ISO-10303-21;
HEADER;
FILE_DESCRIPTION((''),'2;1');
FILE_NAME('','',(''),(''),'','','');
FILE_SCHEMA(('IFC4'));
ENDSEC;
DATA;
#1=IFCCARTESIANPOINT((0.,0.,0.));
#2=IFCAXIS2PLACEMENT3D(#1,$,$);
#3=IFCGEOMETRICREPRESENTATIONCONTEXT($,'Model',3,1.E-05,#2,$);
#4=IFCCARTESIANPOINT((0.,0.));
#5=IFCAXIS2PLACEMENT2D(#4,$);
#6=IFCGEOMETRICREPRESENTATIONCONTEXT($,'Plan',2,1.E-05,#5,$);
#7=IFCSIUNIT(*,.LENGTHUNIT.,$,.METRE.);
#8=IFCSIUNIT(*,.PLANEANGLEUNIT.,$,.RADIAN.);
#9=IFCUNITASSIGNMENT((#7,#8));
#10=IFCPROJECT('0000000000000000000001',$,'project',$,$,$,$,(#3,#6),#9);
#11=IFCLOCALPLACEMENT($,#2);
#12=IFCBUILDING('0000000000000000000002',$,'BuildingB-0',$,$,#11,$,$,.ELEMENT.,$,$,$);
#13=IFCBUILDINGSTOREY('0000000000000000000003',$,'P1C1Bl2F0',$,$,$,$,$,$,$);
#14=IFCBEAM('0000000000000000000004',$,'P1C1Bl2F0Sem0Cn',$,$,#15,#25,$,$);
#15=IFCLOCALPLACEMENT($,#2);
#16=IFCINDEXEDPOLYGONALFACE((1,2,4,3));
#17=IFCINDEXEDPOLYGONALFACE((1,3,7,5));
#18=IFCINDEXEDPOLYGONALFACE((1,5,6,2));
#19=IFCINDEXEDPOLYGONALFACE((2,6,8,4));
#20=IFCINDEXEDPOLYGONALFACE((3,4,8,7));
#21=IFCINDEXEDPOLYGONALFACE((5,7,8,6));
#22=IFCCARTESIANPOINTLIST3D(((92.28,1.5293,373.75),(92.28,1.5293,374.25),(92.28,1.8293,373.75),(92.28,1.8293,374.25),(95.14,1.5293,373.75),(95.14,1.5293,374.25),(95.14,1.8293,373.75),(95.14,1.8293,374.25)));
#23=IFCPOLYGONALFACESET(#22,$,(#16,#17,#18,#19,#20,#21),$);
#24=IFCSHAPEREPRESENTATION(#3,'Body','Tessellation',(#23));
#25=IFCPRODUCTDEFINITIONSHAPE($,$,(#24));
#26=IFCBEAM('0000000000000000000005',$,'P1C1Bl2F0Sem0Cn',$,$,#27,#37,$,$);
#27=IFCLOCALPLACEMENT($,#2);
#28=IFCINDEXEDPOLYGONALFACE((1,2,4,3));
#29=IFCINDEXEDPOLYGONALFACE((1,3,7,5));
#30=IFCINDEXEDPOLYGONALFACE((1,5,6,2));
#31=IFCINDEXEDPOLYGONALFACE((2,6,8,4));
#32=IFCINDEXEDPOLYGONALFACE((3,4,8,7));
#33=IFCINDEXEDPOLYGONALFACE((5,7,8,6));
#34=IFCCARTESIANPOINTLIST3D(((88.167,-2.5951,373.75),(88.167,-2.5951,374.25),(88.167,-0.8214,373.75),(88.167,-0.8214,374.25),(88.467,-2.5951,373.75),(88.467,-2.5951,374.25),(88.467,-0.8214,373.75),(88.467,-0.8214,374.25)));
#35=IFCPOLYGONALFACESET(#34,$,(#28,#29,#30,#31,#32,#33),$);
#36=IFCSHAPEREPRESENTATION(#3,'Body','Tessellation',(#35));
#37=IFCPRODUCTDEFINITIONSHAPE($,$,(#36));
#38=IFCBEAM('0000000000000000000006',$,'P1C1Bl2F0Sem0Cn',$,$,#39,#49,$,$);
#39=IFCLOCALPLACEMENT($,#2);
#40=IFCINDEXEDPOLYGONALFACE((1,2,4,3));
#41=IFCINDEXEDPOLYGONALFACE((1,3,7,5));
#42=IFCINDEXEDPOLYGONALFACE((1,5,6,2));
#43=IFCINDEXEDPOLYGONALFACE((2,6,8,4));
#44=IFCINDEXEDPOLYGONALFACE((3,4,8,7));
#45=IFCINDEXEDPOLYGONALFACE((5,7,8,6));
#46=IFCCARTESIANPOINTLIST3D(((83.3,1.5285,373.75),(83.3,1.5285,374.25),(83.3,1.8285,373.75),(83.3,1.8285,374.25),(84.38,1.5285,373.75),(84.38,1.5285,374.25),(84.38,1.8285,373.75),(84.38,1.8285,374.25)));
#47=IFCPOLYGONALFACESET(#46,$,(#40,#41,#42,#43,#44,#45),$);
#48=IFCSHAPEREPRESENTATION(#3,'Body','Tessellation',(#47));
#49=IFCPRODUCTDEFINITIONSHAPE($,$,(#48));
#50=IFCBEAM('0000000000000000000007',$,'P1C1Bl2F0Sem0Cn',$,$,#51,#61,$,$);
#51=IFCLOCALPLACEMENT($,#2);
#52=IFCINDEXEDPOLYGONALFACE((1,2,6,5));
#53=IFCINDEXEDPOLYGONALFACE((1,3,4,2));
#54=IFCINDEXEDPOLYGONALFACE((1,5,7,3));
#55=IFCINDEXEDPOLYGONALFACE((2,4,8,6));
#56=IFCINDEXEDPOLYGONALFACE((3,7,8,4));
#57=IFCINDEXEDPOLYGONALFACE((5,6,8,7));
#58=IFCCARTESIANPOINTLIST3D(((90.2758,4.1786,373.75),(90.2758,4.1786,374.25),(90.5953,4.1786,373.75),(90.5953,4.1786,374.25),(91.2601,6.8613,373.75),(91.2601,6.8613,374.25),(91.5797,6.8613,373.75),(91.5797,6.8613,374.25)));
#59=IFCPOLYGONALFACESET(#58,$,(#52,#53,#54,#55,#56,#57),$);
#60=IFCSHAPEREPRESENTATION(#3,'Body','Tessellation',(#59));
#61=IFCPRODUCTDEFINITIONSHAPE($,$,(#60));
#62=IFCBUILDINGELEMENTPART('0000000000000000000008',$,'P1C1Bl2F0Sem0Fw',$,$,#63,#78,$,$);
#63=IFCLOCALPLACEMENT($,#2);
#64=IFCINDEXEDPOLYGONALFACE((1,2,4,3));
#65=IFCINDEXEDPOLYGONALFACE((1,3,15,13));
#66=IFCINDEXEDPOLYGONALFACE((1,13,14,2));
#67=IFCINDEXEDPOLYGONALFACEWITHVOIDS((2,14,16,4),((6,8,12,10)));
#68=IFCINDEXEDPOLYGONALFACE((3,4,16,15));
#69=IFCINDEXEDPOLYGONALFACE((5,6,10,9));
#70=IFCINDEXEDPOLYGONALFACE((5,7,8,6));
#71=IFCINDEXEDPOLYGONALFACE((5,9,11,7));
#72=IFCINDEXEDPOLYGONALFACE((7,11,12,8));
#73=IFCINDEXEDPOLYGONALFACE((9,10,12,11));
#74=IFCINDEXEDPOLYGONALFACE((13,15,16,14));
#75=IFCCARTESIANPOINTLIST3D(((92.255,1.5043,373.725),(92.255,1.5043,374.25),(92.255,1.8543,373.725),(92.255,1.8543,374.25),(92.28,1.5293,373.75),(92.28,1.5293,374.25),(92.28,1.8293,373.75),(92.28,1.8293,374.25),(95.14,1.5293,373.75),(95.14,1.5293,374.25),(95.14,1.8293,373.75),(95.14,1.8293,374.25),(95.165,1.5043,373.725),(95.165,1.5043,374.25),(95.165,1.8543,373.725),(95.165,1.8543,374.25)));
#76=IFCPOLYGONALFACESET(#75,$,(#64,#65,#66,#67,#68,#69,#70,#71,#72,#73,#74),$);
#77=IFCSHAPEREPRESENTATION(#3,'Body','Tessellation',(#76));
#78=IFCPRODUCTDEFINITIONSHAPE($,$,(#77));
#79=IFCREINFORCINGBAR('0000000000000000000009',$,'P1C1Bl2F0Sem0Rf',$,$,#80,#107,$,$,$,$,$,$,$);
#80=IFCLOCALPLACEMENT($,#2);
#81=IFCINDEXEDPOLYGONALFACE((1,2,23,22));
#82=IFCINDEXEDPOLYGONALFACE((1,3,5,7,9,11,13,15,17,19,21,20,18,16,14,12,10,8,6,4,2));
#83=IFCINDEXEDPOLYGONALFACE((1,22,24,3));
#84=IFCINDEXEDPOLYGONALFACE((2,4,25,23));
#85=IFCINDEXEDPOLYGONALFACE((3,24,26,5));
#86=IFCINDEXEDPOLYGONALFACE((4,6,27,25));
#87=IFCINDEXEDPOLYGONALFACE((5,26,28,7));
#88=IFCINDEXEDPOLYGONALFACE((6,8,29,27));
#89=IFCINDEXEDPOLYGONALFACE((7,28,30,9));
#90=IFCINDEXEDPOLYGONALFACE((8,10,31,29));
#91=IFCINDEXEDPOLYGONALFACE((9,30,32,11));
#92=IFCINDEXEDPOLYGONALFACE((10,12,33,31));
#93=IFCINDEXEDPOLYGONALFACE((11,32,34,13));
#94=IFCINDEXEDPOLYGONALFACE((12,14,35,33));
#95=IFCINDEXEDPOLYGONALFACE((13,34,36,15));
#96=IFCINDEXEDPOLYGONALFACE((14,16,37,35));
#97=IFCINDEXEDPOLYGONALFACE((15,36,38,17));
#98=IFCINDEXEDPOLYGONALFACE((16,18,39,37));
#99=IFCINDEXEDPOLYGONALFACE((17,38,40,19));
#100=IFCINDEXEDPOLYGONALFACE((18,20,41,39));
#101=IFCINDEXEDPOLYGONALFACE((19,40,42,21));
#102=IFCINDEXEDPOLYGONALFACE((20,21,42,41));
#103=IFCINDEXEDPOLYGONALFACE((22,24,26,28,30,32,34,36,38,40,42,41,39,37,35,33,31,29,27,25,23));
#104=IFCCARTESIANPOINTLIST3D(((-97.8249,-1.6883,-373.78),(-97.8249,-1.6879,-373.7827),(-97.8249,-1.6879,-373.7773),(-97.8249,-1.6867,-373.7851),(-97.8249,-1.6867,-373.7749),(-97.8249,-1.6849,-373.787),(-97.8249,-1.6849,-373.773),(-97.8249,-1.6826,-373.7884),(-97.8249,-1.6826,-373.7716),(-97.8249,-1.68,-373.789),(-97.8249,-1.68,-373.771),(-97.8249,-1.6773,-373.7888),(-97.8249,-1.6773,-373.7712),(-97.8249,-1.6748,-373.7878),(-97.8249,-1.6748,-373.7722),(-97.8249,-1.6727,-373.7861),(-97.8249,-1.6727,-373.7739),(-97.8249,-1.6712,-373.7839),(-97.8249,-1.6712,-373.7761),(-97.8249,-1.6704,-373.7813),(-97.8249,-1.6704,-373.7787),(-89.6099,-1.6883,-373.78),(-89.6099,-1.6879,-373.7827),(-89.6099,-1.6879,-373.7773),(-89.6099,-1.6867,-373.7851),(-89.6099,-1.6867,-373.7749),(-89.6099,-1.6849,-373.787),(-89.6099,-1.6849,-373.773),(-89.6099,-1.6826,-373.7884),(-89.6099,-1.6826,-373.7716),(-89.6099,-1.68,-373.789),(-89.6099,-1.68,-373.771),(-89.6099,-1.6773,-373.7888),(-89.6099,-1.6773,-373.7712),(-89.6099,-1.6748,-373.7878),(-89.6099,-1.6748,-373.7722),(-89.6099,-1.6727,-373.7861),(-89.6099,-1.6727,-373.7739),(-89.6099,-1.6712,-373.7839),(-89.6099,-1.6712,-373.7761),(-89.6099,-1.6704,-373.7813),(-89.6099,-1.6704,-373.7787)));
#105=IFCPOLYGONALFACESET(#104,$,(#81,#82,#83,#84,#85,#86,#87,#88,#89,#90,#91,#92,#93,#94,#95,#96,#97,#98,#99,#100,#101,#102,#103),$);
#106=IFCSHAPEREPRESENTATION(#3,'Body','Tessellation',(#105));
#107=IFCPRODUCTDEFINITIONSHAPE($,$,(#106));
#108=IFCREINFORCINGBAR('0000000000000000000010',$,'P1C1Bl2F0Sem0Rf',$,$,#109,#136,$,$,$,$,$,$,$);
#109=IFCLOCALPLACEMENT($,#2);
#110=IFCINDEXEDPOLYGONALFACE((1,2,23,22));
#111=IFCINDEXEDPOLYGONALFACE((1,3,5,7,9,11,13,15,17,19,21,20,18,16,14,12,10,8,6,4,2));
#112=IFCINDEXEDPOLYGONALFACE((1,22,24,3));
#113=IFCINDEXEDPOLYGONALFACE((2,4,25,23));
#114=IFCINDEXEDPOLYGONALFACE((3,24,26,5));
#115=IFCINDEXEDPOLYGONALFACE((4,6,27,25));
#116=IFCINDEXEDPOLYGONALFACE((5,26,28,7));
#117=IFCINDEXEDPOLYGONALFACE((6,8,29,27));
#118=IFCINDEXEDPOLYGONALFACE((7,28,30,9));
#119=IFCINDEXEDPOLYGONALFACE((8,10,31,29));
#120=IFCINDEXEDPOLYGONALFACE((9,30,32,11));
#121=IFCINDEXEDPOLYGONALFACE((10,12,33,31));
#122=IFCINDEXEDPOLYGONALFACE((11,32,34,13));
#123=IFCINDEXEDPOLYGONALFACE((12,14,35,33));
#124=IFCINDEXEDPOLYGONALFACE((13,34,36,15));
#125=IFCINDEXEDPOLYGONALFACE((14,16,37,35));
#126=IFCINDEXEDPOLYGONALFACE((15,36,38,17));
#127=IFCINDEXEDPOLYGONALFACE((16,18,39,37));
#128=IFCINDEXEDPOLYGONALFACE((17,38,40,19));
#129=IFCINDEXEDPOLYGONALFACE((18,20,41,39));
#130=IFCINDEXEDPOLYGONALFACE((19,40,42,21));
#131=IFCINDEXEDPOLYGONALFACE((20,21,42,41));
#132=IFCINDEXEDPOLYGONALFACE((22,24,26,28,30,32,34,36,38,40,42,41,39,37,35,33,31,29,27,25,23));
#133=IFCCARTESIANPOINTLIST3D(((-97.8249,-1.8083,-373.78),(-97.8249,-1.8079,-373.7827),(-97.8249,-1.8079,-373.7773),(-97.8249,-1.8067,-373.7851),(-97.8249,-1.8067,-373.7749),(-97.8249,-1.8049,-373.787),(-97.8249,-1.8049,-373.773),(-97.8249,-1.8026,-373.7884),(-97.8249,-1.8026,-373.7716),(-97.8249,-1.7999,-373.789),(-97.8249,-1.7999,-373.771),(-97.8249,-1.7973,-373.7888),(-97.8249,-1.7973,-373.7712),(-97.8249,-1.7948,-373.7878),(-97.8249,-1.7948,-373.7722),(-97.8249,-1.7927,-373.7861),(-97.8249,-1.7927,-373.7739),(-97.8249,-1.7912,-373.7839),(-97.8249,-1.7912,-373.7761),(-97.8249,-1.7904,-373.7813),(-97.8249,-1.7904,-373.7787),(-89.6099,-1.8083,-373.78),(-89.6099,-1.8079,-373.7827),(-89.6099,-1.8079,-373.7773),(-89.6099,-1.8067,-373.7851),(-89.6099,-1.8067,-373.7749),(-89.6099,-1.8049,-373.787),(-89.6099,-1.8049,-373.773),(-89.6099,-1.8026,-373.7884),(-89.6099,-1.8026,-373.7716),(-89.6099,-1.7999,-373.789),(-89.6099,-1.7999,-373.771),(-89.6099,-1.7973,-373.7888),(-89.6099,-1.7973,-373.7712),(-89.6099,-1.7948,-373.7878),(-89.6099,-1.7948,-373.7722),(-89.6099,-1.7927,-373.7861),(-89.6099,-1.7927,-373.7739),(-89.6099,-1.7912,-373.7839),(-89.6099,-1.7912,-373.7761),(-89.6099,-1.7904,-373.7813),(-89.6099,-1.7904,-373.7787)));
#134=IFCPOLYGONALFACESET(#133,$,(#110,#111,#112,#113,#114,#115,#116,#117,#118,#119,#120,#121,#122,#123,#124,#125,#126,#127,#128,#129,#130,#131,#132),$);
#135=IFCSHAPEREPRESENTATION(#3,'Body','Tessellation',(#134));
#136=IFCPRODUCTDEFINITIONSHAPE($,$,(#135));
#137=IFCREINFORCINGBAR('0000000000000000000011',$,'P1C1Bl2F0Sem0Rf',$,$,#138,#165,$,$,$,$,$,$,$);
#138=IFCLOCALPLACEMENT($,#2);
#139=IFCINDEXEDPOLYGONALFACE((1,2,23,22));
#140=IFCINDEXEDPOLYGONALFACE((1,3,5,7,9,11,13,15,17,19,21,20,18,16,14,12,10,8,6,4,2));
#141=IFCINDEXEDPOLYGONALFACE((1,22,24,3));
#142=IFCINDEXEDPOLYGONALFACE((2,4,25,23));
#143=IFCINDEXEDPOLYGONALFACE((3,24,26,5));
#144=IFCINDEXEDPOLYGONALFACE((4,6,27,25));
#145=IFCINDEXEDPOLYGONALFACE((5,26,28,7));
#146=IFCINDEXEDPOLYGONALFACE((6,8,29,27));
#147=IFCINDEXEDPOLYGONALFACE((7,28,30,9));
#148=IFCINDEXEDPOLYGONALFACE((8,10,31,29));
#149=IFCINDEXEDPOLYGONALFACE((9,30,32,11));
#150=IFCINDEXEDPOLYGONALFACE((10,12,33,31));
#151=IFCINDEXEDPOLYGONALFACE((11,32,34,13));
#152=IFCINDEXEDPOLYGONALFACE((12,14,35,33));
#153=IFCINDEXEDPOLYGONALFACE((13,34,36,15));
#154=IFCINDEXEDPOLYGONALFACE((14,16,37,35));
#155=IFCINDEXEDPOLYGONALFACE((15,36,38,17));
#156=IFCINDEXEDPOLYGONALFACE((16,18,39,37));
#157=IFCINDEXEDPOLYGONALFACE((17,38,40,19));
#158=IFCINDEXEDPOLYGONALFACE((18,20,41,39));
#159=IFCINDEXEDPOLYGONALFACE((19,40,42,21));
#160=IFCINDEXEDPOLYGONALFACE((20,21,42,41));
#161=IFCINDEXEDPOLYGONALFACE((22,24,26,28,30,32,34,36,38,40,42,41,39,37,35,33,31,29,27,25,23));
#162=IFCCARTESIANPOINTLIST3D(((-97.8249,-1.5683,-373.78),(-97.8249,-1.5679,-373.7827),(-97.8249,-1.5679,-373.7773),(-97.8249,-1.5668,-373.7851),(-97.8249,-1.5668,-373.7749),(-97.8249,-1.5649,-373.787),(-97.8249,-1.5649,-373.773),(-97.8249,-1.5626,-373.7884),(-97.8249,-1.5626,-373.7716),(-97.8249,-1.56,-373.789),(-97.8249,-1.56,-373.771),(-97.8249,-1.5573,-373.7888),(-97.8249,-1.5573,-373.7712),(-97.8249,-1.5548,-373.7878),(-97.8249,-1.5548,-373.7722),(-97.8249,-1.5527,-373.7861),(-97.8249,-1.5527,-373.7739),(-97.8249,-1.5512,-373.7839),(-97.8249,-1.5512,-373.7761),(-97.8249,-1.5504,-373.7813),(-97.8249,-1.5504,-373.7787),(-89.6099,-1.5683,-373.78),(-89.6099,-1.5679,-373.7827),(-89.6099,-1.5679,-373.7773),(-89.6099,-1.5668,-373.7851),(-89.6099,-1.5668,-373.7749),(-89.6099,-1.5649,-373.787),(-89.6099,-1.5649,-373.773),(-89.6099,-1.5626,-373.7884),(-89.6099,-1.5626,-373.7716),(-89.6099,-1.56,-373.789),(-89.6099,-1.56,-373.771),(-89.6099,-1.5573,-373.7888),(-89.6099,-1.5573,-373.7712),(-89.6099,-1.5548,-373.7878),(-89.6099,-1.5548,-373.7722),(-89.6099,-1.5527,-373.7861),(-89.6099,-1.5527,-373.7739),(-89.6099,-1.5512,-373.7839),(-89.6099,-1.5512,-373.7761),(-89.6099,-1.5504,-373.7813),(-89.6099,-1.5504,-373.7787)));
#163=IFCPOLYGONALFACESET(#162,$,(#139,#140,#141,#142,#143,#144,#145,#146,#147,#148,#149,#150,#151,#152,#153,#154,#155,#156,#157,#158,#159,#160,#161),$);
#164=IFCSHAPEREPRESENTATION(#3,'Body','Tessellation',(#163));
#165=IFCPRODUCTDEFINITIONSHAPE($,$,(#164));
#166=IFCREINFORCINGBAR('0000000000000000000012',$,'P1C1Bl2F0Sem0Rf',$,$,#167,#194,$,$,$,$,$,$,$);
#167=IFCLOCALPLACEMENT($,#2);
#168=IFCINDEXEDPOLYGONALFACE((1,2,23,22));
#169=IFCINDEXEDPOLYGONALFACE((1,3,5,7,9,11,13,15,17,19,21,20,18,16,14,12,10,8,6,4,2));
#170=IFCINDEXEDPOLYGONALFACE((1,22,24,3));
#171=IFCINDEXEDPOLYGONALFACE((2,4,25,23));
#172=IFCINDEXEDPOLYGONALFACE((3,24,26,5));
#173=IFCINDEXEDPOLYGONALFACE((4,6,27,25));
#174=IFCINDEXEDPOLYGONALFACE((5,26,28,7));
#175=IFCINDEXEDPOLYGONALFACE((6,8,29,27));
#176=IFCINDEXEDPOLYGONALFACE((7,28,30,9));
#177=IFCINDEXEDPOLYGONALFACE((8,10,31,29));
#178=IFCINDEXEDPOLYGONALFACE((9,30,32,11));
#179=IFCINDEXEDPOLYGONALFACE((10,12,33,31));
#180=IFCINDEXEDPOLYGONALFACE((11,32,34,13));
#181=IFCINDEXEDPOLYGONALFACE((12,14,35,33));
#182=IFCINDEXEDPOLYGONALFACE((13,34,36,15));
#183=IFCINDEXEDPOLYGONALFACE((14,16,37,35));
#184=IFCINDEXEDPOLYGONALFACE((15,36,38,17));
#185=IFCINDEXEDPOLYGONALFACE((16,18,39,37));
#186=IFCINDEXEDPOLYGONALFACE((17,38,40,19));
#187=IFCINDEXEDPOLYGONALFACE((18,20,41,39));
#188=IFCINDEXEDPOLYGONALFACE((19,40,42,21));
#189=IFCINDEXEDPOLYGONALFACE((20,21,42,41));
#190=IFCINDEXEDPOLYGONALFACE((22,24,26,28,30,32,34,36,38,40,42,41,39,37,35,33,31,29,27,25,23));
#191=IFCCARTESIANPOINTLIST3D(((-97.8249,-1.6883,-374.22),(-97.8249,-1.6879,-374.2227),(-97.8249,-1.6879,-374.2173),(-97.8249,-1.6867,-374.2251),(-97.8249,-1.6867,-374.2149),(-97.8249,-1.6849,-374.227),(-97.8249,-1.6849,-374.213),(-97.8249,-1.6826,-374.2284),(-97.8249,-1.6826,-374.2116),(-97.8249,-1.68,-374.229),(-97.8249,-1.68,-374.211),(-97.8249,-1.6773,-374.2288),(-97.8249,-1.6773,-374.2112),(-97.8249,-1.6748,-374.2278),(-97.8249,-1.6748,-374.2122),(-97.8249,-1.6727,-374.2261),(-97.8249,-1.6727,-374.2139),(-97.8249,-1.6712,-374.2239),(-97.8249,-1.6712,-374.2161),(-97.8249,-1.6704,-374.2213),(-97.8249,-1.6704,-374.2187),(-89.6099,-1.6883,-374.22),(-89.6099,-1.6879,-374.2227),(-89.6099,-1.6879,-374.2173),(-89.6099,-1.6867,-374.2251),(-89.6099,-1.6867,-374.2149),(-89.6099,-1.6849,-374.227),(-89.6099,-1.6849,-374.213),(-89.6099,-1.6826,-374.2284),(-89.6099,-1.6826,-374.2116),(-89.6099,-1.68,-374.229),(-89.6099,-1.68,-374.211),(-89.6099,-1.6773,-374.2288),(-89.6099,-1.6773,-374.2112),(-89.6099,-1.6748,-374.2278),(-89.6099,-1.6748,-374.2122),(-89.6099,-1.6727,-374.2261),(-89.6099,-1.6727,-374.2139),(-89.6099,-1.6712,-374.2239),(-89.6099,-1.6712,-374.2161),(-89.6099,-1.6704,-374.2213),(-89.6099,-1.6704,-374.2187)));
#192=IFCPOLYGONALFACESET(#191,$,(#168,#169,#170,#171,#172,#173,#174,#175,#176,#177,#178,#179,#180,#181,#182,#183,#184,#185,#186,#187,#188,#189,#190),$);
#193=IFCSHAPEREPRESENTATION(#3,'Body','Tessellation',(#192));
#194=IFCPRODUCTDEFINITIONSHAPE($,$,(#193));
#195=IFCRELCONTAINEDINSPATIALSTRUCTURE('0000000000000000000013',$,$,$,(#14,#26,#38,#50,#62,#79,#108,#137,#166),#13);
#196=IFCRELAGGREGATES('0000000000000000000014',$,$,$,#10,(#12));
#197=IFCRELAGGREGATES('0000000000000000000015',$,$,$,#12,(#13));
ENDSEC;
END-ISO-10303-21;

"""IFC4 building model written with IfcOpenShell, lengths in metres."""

from ifc_helpers import new_model, entity, si_unit, origin, origin_2d, place, context, project, spatial, polyline, outline, extrude, element, save


model = new_model("IFC4")

# Units and contexts
model_context = context("Model", 3, precision=1e-05, world=origin())
plan_context = context("Plan", 2, precision=1e-05, world=origin_2d())
ifc_project = project(units=[si_unit("LENGTHUNIT", "METRE"), si_unit("PLANEANGLEUNIT", "RADIAN")], contexts=[model_context, plan_context])

# Building, storey
building_placement = place(None, origin())
building = spatial("IfcBuilding", under=ifc_project, at=building_placement, Name="BuildingB-0", CompositionType="ELEMENT")
storey = spatial("IfcBuildingStorey", under=building, Name="P1C1Bl2F0")

# Beams
element("IfcBeam", 1, inside=storey, Name="P1C1Bl2F0Sem0Cn", context=model_context, shape_type="SweptSolid", body=[
    extrude(outline(polyline([(95.14, 1.5293, 373.75), (95.14, 1.8293, 373.75), (92.28, 1.8293, 373.75), (92.28, 1.5293, 373.75), (95.14, 1.5293, 373.75)])), None, (0.0, 0.0, 1.0), 0.5),
])
element("IfcBeam", 2, inside=storey, Name="P1C1Bl2F0Sem0Cn", context=model_context, shape_type="SweptSolid", body=[
    extrude(outline(polyline([(88.467, -2.5951, 373.75), (88.467, -0.8214, 373.75), (88.167, -0.8214, 373.75), (88.167, -2.5951, 373.75), (88.467, -2.5951, 373.75)])), None, (0.0, 0.0, 1.0), 0.5),
])
element("IfcBeam", 3, inside=storey, Name="P1C1Bl2F0Sem0Cn", context=model_context, shape_type="SweptSolid", body=[
    extrude(outline(polyline([(84.38, 1.5285, 373.75), (84.38, 1.8285, 373.75), (83.3, 1.8285, 373.75), (83.3, 1.5285, 373.75), (84.38, 1.5285, 373.75)])), None, (0.0, 0.0, 1.0), 0.5),
])
element("IfcBeam", 4, inside=storey, Name="P1C1Bl2F0Sem0Cn", context=model_context, shape_type="SweptSolid", body=[
    extrude(outline(polyline([(90.5953, 4.1786, 373.75), (90.2758, 4.1786, 373.75), (91.2601, 6.8613, 373.75), (91.5797, 6.8613, 373.75), (90.5953, 4.1786, 373.75)])), None, (0.0, 0.0, 1.0), 0.5),
])

# Building element part, opening
building_element_part_1 = element("IfcBuildingElementPart", 5, inside=storey, Name="P1C1Bl2F0Sem0Fw", context=model_context, shape_type="SweptSolid", body=[
    extrude(outline(polyline([(95.165, 1.5043, 373.725), (95.165, 1.8543, 373.725), (92.255, 1.8543, 373.725), (92.255, 1.5043, 373.725), (95.165, 1.5043, 373.725)])), None, (0.0, 0.0, 1.0), 0.525),
])
element("IfcOpeningElement", 6, inside=storey, cuts=building_element_part_1, context=model_context, shape_type="SweptSolid", body=[
    extrude(outline(polyline([(95.14, 1.5293, 373.75), (95.14, 1.8293, 373.75), (92.28, 1.8293, 373.75), (92.28, 1.5293, 373.75), (95.14, 1.5293, 373.75)])), None, (0.0, 0.0, 1.0), 0.5),
])

# Reinforcing bars
element("IfcReinforcingBar", 7, inside=storey, Name="P1C1Bl2F0Sem0Rf", context=model_context, shape_type="SweptSolid", body=[
    entity("IfcSurfaceCurveSweptAreaSolid", entity("IfcCircleProfileDef", "AREA", None, None, 0.009), None, entity("IfcPolyline", [entity("IfcCartesianPoint", [97.8249, 1.6793, 373.78]), entity("IfcCartesianPoint", [89.6099, 1.6793, 373.78])]), None, None, entity("IfcPlane", entity("IfcAxis2Placement3D", entity("IfcCartesianPoint", [97.8249, 1.6793, 373.78]), entity("IfcDirection", [0.0, 0.0, 1.0]), entity("IfcDirection", [1.0, 0.0, 0.0])))),
])
element("IfcReinforcingBar", 8, inside=storey, Name="P1C1Bl2F0Sem0Rf", context=model_context, shape_type="SweptSolid", body=[
    entity("IfcSurfaceCurveSweptAreaSolid", entity("IfcCircleProfileDef", "AREA", None, None, 0.009), None, entity("IfcPolyline", [entity("IfcCartesianPoint", [97.8249, 1.7993, 373.78]), entity("IfcCartesianPoint", [89.6099, 1.7993, 373.78])]), None, None, entity("IfcPlane", entity("IfcAxis2Placement3D", entity("IfcCartesianPoint", [97.8249, 1.7993, 373.78]), entity("IfcDirection", [0.0, 0.0, 1.0]), entity("IfcDirection", [1.0, 0.0, 0.0])))),
])
element("IfcReinforcingBar", 9, inside=storey, Name="P1C1Bl2F0Sem0Rf", context=model_context, shape_type="SweptSolid", body=[
    entity("IfcSurfaceCurveSweptAreaSolid", entity("IfcCircleProfileDef", "AREA", None, None, 0.009), None, entity("IfcPolyline", [entity("IfcCartesianPoint", [97.8249, 1.5593, 373.78]), entity("IfcCartesianPoint", [89.6099, 1.5593, 373.78])]), None, None, entity("IfcPlane", entity("IfcAxis2Placement3D", entity("IfcCartesianPoint", [97.8249, 1.5593, 373.78]), entity("IfcDirection", [0.0, 0.0, 1.0]), entity("IfcDirection", [1.0, 0.0, 0.0])))),
])
element("IfcReinforcingBar", 10, inside=storey, Name="P1C1Bl2F0Sem0Rf", context=model_context, shape_type="SweptSolid", body=[
    entity("IfcSurfaceCurveSweptAreaSolid", entity("IfcCircleProfileDef", "AREA", None, None, 0.009), None, entity("IfcPolyline", [entity("IfcCartesianPoint", [97.8249, 1.6793, 374.22]), entity("IfcCartesianPoint", [89.6099, 1.6793, 374.22])]), None, None, entity("IfcPlane", entity("IfcAxis2Placement3D", entity("IfcCartesianPoint", [97.8249, 1.6793, 374.22]), entity("IfcDirection", [0.0, 0.0, 1.0]), entity("IfcDirection", [1.0, 0.0, 0.0])))),
])

save(model, "model.ifc")
